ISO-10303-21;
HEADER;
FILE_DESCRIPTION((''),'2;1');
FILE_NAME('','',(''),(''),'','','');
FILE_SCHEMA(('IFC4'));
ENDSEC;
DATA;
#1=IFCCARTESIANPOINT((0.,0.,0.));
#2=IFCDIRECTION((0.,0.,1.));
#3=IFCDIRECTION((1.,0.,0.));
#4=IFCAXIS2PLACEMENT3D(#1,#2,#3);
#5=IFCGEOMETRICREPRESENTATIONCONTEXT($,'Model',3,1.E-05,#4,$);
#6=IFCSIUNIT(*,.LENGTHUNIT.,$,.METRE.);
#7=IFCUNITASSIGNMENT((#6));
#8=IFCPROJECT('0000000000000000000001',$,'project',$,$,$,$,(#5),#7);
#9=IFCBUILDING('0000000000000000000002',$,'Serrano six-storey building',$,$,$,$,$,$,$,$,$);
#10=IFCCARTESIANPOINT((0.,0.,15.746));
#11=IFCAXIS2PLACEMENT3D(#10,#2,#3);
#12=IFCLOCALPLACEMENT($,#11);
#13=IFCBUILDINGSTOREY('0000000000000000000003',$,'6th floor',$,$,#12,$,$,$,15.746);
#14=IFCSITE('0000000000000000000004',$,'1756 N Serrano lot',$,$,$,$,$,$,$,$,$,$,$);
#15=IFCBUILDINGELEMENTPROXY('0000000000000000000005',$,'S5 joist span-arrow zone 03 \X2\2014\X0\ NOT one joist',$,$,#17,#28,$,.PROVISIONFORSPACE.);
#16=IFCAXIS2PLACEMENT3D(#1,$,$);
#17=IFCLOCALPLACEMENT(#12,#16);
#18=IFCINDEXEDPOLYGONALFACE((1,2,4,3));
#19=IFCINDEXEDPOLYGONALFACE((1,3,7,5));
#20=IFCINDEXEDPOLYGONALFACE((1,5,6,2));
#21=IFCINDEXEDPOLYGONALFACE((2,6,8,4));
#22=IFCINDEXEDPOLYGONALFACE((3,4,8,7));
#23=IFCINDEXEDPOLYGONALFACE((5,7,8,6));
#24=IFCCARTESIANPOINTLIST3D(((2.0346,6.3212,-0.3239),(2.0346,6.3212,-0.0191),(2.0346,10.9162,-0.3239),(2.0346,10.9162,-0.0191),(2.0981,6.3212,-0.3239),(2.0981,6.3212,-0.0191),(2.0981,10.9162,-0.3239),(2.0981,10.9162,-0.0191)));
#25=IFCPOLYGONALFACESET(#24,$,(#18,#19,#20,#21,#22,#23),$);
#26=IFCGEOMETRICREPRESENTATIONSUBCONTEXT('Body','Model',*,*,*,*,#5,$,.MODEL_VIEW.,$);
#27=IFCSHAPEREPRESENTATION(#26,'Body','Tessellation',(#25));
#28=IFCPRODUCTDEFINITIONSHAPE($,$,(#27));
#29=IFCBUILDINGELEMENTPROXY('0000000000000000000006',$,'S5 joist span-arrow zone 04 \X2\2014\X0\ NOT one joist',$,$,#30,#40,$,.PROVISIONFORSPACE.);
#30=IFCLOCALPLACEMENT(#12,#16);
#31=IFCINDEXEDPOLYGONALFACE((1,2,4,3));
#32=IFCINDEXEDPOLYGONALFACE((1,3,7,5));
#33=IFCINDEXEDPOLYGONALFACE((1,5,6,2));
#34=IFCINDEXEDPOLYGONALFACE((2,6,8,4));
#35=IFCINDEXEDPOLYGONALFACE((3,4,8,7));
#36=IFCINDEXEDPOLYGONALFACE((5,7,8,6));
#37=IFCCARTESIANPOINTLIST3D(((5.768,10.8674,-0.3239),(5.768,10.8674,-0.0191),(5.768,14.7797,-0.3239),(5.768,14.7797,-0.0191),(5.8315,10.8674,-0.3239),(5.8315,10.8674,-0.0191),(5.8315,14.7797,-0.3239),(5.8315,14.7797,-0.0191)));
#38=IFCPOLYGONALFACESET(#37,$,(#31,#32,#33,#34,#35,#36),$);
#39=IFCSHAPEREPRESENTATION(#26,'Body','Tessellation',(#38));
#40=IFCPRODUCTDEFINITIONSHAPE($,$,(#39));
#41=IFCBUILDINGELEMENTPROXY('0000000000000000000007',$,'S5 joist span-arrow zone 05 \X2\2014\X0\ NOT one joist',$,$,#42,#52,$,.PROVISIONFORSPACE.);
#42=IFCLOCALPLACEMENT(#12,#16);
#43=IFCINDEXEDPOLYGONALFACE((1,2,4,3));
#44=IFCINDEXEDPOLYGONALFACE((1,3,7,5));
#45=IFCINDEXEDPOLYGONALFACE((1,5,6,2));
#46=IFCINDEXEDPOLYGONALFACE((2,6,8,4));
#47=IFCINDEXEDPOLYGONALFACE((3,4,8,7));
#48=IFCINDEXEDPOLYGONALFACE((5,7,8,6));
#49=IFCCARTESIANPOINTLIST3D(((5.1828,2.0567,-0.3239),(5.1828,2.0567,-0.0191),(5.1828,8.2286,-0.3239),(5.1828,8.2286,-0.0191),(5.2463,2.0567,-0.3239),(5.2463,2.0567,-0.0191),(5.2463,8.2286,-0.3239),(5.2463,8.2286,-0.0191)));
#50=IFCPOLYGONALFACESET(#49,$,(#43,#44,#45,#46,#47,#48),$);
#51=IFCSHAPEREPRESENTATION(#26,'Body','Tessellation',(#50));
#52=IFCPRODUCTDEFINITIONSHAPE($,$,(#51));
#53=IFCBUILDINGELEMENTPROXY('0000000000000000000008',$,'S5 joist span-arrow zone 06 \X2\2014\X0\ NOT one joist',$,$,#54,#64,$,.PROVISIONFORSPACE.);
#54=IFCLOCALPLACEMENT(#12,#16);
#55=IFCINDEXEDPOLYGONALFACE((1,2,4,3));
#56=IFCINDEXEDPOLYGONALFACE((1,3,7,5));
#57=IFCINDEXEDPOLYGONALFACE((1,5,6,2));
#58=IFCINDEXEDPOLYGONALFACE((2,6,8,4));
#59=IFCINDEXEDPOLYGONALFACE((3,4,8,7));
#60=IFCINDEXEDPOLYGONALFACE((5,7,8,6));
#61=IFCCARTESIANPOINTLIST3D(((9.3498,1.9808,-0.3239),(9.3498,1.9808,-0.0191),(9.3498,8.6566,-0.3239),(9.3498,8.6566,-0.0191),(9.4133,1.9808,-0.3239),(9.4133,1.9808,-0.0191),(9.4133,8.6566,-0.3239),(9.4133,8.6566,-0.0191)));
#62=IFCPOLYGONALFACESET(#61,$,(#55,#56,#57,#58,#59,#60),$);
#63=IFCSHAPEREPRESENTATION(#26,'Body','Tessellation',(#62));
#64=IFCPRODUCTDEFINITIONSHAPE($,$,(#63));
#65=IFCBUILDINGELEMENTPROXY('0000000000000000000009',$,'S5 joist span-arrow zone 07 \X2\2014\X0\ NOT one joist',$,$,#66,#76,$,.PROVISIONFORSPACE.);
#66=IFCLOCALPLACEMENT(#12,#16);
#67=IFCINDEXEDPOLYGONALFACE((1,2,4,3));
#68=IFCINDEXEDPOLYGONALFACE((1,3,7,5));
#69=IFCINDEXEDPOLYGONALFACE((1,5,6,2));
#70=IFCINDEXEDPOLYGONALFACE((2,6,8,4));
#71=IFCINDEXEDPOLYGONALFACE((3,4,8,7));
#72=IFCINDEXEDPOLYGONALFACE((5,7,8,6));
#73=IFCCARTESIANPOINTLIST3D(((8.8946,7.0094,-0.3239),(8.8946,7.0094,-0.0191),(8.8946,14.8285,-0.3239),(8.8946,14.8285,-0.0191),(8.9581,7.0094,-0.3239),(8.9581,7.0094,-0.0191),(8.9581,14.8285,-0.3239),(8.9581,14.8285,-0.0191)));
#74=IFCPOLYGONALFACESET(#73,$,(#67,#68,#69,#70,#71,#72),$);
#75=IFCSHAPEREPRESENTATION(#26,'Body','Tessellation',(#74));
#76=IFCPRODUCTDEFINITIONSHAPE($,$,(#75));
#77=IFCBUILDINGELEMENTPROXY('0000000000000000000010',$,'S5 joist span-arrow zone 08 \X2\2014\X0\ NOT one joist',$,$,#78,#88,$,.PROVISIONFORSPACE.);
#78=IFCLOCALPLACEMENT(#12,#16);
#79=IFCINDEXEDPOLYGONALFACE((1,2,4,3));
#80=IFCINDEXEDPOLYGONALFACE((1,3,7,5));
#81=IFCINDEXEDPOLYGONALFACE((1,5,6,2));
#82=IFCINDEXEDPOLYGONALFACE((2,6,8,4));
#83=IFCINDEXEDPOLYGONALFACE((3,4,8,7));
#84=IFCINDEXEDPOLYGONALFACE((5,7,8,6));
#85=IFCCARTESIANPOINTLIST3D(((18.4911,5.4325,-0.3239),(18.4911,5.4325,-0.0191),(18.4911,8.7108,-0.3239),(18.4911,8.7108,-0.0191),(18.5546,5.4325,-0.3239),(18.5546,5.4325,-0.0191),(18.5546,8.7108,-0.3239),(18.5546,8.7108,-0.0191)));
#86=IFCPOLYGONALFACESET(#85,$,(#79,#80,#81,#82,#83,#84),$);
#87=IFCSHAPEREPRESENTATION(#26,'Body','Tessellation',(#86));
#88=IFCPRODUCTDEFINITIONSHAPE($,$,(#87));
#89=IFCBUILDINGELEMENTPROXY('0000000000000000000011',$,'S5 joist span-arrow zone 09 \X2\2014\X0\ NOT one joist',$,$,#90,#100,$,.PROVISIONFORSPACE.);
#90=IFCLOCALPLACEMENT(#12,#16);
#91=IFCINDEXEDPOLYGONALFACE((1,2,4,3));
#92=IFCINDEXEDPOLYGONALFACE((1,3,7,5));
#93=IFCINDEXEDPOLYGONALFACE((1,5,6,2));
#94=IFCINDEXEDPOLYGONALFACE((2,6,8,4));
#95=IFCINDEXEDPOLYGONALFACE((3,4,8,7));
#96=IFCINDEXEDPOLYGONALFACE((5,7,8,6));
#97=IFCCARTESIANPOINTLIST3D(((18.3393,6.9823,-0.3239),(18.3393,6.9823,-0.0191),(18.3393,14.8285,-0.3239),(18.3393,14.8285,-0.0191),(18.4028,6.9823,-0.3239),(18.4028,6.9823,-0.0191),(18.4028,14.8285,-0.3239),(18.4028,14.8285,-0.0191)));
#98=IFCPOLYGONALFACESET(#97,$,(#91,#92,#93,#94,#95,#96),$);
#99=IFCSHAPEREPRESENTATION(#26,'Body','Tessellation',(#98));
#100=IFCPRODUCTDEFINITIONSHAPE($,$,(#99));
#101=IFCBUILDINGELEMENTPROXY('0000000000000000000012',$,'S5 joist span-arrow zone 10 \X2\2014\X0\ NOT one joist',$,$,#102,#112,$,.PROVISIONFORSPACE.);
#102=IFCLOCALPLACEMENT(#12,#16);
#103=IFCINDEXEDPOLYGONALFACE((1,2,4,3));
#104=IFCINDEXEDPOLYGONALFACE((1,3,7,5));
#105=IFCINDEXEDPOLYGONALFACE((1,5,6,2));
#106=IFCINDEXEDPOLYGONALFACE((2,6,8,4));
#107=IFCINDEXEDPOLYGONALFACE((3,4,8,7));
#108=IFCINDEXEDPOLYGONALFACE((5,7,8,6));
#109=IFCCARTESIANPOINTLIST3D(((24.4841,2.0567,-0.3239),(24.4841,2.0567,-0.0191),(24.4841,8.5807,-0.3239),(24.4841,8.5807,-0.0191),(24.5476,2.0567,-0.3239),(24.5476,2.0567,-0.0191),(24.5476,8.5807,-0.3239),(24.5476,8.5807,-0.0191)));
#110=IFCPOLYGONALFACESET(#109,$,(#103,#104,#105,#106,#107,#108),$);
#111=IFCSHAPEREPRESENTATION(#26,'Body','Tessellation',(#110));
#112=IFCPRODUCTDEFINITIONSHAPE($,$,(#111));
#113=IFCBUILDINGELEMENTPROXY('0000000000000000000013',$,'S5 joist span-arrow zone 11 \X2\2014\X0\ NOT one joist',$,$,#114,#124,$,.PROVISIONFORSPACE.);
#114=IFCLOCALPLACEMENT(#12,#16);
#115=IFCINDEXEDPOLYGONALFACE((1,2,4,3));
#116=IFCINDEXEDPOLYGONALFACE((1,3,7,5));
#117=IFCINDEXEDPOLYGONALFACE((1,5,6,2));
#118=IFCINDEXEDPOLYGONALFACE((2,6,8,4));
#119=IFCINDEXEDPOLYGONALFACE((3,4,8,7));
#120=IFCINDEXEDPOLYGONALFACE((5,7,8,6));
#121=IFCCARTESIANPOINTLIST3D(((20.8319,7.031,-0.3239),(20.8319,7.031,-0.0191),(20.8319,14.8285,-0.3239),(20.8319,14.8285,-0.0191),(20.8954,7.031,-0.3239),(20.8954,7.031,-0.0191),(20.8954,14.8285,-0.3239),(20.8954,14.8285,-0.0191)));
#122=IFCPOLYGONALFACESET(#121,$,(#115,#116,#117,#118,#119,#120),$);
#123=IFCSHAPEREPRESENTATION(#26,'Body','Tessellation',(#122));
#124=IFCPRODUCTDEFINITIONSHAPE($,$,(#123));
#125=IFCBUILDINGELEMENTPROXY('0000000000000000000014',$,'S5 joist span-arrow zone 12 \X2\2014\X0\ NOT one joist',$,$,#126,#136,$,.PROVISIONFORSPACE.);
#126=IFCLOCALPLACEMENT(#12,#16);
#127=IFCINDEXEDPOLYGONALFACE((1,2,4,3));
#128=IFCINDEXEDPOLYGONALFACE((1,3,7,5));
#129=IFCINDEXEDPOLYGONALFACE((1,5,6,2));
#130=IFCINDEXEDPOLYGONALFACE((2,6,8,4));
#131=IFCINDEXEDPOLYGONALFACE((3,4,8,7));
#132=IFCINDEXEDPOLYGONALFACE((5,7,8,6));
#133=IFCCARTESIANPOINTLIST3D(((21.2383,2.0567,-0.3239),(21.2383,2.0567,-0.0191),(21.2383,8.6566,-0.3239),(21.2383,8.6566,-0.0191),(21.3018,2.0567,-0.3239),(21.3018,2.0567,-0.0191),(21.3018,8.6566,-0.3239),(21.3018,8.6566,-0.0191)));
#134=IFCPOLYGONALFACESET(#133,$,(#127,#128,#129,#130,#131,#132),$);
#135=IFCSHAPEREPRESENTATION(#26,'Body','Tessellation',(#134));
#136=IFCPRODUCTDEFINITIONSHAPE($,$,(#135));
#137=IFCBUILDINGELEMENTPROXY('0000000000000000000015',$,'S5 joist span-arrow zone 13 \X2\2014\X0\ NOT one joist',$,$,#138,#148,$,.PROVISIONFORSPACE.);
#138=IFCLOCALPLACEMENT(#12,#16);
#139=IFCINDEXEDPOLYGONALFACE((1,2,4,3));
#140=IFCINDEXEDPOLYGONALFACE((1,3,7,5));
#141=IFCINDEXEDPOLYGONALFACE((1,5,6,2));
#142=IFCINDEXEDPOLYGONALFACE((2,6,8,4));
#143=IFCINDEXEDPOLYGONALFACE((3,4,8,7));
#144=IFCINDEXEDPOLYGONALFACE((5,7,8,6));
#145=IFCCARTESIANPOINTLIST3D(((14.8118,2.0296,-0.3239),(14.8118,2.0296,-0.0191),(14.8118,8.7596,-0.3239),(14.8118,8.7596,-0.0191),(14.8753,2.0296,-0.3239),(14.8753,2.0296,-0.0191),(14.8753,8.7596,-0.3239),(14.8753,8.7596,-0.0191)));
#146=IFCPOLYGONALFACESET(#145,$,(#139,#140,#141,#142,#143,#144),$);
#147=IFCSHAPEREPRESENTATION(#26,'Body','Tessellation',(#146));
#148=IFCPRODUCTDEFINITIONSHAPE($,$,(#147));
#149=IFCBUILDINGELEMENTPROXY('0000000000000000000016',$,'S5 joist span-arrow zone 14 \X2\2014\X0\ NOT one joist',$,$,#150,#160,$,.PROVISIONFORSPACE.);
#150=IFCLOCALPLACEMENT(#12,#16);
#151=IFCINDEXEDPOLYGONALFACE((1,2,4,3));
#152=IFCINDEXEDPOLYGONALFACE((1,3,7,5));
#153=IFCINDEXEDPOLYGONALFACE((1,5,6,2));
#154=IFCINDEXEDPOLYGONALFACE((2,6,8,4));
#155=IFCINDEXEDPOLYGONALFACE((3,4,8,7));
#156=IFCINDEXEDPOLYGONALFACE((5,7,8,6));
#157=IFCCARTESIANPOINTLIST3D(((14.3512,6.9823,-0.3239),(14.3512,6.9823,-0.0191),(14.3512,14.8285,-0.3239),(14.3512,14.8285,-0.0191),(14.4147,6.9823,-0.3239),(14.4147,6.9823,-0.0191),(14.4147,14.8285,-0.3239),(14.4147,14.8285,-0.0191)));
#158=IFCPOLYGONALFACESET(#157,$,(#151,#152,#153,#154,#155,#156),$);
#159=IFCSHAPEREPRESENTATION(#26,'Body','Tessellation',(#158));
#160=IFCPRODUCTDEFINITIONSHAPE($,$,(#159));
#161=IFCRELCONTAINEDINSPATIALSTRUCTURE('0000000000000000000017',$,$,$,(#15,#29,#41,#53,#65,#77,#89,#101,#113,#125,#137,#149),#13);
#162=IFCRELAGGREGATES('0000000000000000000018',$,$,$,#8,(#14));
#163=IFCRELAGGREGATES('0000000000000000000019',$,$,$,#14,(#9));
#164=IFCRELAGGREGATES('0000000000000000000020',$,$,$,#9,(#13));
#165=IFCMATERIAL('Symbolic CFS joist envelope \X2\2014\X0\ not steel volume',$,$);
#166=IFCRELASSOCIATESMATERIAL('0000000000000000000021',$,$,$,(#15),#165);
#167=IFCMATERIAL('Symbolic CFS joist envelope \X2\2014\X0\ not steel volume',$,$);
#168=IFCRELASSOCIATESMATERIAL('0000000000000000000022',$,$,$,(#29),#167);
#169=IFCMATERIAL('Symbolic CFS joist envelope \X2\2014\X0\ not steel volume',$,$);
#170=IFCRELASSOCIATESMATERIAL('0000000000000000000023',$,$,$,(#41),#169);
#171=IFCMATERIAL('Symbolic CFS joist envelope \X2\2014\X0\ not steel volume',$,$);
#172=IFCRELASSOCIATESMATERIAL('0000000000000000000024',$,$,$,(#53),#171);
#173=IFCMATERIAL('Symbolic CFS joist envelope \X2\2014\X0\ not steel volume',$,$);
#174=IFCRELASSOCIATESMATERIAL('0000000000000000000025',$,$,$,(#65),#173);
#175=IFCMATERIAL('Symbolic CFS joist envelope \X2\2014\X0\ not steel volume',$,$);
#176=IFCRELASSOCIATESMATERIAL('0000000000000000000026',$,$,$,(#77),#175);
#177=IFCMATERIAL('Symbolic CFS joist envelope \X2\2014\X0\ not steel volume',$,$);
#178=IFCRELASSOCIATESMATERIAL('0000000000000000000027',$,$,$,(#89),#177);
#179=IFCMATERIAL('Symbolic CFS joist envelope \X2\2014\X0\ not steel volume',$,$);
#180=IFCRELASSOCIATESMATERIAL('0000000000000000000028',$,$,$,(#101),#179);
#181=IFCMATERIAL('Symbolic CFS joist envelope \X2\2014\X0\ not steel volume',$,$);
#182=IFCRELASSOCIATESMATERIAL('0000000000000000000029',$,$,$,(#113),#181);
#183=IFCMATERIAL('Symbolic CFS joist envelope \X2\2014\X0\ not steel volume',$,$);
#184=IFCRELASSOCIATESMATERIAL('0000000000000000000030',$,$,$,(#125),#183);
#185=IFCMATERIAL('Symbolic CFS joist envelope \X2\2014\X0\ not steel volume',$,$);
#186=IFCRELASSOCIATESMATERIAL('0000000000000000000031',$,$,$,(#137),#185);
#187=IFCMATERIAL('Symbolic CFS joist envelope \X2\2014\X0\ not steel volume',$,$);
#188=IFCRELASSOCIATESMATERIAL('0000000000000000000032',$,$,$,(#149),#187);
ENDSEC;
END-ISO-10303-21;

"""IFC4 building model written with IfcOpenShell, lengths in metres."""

from ifc_helpers import new_model, si_unit, frame, origin_with_axes, place, context, subcontext, project, spatial, polyline, outline, extrude, material, element, save


model = new_model("IFC4")

# Units and contexts
model_context = context("Model", 3, precision=1e-05, world=origin_with_axes())
body_context = subcontext(model_context, "Body", "Model", "MODEL_VIEW")
ifc_project = project(units=[si_unit("LENGTHUNIT", "METRE")], contexts=[model_context])

# Site, building, storey
site = spatial("IfcSite", under=ifc_project, Name="1756 N Serrano lot")
building = spatial("IfcBuilding", under=site, Name="Serrano six-storey building")
storey_placement = place(None, frame((0.0, 0.0, 15.746), z_axis=(0.0, 0.0, 1.0), x_axis=(1.0, 0.0, 0.0)))
storey = spatial("IfcBuildingStorey", under=building, at=storey_placement, Name="6th floor", Elevation=15.746)

# Building element proxies
ifc_material_1 = material(Name="Symbolic CFS joist envelope — not steel volume")
proxy_1_placement = place(storey_placement, frame((0.0, 0.0, -15.746), z_axis=(0.0, 0.0, 1.0), x_axis=(1.0, 0.0, 0.0)))
element("IfcBuildingElementProxy", 1, at=proxy_1_placement, inside=storey, material=ifc_material_1, Name="S5 joist span-arrow zone 03 — NOT one joist", PredefinedType="PROVISIONFORSPACE", context=body_context, shape_type="SweptSolid", body=[
    extrude(outline(polyline([(2.0346, 10.9162), (2.0981, 10.9162), (2.0981, 6.3212), (2.0346, 6.3212), (2.0346, 10.9162)])), frame((0.0, 0.0, 15.4221)), (0.0, 0.0, 1.0), 0.3048),
])
ifc_material_2 = material(Name="Symbolic CFS joist envelope — not steel volume")
proxy_2_placement = place(storey_placement, frame((0.0, 0.0, -15.746), z_axis=(0.0, 0.0, 1.0), x_axis=(1.0, 0.0, 0.0)))
element("IfcBuildingElementProxy", 2, at=proxy_2_placement, inside=storey, material=ifc_material_2, Name="S5 joist span-arrow zone 04 — NOT one joist", PredefinedType="PROVISIONFORSPACE", context=body_context, shape_type="SweptSolid", body=[
    extrude(outline(polyline([(5.768, 14.7797), (5.8315, 14.7797), (5.8315, 10.8674), (5.768, 10.8674), (5.768, 14.7797)])), frame((0.0, 0.0, 15.4221)), (0.0, 0.0, 1.0), 0.3048),
])
ifc_material_3 = material(Name="Symbolic CFS joist envelope — not steel volume")
proxy_3_placement = place(storey_placement, frame((0.0, 0.0, -15.746), z_axis=(0.0, 0.0, 1.0), x_axis=(1.0, 0.0, 0.0)))
element("IfcBuildingElementProxy", 3, at=proxy_3_placement, inside=storey, material=ifc_material_3, Name="S5 joist span-arrow zone 05 — NOT one joist", PredefinedType="PROVISIONFORSPACE", context=body_context, shape_type="SweptSolid", body=[
    extrude(outline(polyline([(5.1828, 8.2286), (5.2463, 8.2286), (5.2463, 2.0567), (5.1828, 2.0567), (5.1828, 8.2286)])), frame((0.0, 0.0, 15.4221)), (0.0, 0.0, 1.0), 0.3048),
])
ifc_material_4 = material(Name="Symbolic CFS joist envelope — not steel volume")
proxy_4_placement = place(storey_placement, frame((0.0, 0.0, -15.746), z_axis=(0.0, 0.0, 1.0), x_axis=(1.0, 0.0, 0.0)))
element("IfcBuildingElementProxy", 4, at=proxy_4_placement, inside=storey, material=ifc_material_4, Name="S5 joist span-arrow zone 06 — NOT one joist", PredefinedType="PROVISIONFORSPACE", context=body_context, shape_type="SweptSolid", body=[
    extrude(outline(polyline([(9.3498, 8.6566), (9.4133, 8.6566), (9.4133, 1.9808), (9.3498, 1.9808), (9.3498, 8.6566)])), frame((0.0, 0.0, 15.4221)), (0.0, 0.0, 1.0), 0.3048),
])
ifc_material_5 = material(Name="Symbolic CFS joist envelope — not steel volume")
proxy_5_placement = place(storey_placement, frame((0.0, 0.0, -15.746), z_axis=(0.0, 0.0, 1.0), x_axis=(1.0, 0.0, 0.0)))
element("IfcBuildingElementProxy", 5, at=proxy_5_placement, inside=storey, material=ifc_material_5, Name="S5 joist span-arrow zone 07 — NOT one joist", PredefinedType="PROVISIONFORSPACE", context=body_context, shape_type="SweptSolid", body=[
    extrude(outline(polyline([(8.8946, 14.8285), (8.9581, 14.8285), (8.9581, 7.0094), (8.8946, 7.0094), (8.8946, 14.8285)])), frame((0.0, 0.0, 15.4221)), (0.0, 0.0, 1.0), 0.3048),
])
ifc_material_6 = material(Name="Symbolic CFS joist envelope — not steel volume")
proxy_6_placement = place(storey_placement, frame((0.0, 0.0, -15.746), z_axis=(0.0, 0.0, 1.0), x_axis=(1.0, 0.0, 0.0)))
element("IfcBuildingElementProxy", 6, at=proxy_6_placement, inside=storey, material=ifc_material_6, Name="S5 joist span-arrow zone 08 — NOT one joist", PredefinedType="PROVISIONFORSPACE", context=body_context, shape_type="SweptSolid", body=[
    extrude(outline(polyline([(18.4911, 8.7108), (18.5546, 8.7108), (18.5546, 5.4325), (18.4911, 5.4325), (18.4911, 8.7108)])), frame((0.0, 0.0, 15.4221)), (0.0, 0.0, 1.0), 0.3048),
])
ifc_material_7 = material(Name="Symbolic CFS joist envelope — not steel volume")
proxy_7_placement = place(storey_placement, frame((0.0, 0.0, -15.746), z_axis=(0.0, 0.0, 1.0), x_axis=(1.0, 0.0, 0.0)))
element("IfcBuildingElementProxy", 7, at=proxy_7_placement, inside=storey, material=ifc_material_7, Name="S5 joist span-arrow zone 09 — NOT one joist", PredefinedType="PROVISIONFORSPACE", context=body_context, shape_type="SweptSolid", body=[
    extrude(outline(polyline([(18.3393, 14.8285), (18.4028, 14.8285), (18.4028, 6.9823), (18.3393, 6.9823), (18.3393, 14.8285)])), frame((0.0, 0.0, 15.4221)), (0.0, 0.0, 1.0), 0.3048),
])
ifc_material_8 = material(Name="Symbolic CFS joist envelope — not steel volume")
proxy_8_placement = place(storey_placement, frame((0.0, 0.0, -15.746), z_axis=(0.0, 0.0, 1.0), x_axis=(1.0, 0.0, 0.0)))
element("IfcBuildingElementProxy", 8, at=proxy_8_placement, inside=storey, material=ifc_material_8, Name="S5 joist span-arrow zone 10 — NOT one joist", PredefinedType="PROVISIONFORSPACE", context=body_context, shape_type="SweptSolid", body=[
    extrude(outline(polyline([(24.4841, 8.5807), (24.5476, 8.5807), (24.5476, 2.0567), (24.4841, 2.0567), (24.4841, 8.5807)])), frame((0.0, 0.0, 15.4221)), (0.0, 0.0, 1.0), 0.3048),
])
ifc_material_9 = material(Name="Symbolic CFS joist envelope — not steel volume")
proxy_9_placement = place(storey_placement, frame((0.0, 0.0, -15.746), z_axis=(0.0, 0.0, 1.0), x_axis=(1.0, 0.0, 0.0)))
element("IfcBuildingElementProxy", 9, at=proxy_9_placement, inside=storey, material=ifc_material_9, Name="S5 joist span-arrow zone 11 — NOT one joist", PredefinedType="PROVISIONFORSPACE", context=body_context, shape_type="SweptSolid", body=[
    extrude(outline(polyline([(20.8319, 14.8285), (20.8954, 14.8285), (20.8954, 7.031), (20.8319, 7.031), (20.8319, 14.8285)])), frame((0.0, 0.0, 15.4221)), (0.0, 0.0, 1.0), 0.3048),
])
ifc_material_10 = material(Name="Symbolic CFS joist envelope — not steel volume")
proxy_10_placement = place(storey_placement, frame((0.0, 0.0, -15.746), z_axis=(0.0, 0.0, 1.0), x_axis=(1.0, 0.0, 0.0)))
element("IfcBuildingElementProxy", 10, at=proxy_10_placement, inside=storey, material=ifc_material_10, Name="S5 joist span-arrow zone 12 — NOT one joist", PredefinedType="PROVISIONFORSPACE", context=body_context, shape_type="SweptSolid", body=[
    extrude(outline(polyline([(21.2383, 8.6566), (21.3018, 8.6566), (21.3018, 2.0567), (21.2383, 2.0567), (21.2383, 8.6566)])), frame((0.0, 0.0, 15.4221)), (0.0, 0.0, 1.0), 0.3048),
])
ifc_material_11 = material(Name="Symbolic CFS joist envelope — not steel volume")
proxy_11_placement = place(storey_placement, frame((0.0, 0.0, -15.746), z_axis=(0.0, 0.0, 1.0), x_axis=(1.0, 0.0, 0.0)))
element("IfcBuildingElementProxy", 11, at=proxy_11_placement, inside=storey, material=ifc_material_11, Name="S5 joist span-arrow zone 13 — NOT one joist", PredefinedType="PROVISIONFORSPACE", context=body_context, shape_type="SweptSolid", body=[
    extrude(outline(polyline([(14.8118, 8.7596), (14.8753, 8.7596), (14.8753, 2.0296), (14.8118, 2.0296), (14.8118, 8.7596)])), frame((0.0, 0.0, 15.4221)), (0.0, 0.0, 1.0), 0.3048),
])
ifc_material_12 = material(Name="Symbolic CFS joist envelope — not steel volume")
proxy_12_placement = place(storey_placement, frame((0.0, 0.0, -15.746), z_axis=(0.0, 0.0, 1.0), x_axis=(1.0, 0.0, 0.0)))
element("IfcBuildingElementProxy", 12, at=proxy_12_placement, inside=storey, material=ifc_material_12, Name="S5 joist span-arrow zone 14 — NOT one joist", PredefinedType="PROVISIONFORSPACE", context=body_context, shape_type="SweptSolid", body=[
    extrude(outline(polyline([(14.3512, 14.8285), (14.4147, 14.8285), (14.4147, 6.9823), (14.3512, 6.9823), (14.3512, 14.8285)])), frame((0.0, 0.0, 15.4221)), (0.0, 0.0, 1.0), 0.3048),
])

save(model, "model.ifc")
